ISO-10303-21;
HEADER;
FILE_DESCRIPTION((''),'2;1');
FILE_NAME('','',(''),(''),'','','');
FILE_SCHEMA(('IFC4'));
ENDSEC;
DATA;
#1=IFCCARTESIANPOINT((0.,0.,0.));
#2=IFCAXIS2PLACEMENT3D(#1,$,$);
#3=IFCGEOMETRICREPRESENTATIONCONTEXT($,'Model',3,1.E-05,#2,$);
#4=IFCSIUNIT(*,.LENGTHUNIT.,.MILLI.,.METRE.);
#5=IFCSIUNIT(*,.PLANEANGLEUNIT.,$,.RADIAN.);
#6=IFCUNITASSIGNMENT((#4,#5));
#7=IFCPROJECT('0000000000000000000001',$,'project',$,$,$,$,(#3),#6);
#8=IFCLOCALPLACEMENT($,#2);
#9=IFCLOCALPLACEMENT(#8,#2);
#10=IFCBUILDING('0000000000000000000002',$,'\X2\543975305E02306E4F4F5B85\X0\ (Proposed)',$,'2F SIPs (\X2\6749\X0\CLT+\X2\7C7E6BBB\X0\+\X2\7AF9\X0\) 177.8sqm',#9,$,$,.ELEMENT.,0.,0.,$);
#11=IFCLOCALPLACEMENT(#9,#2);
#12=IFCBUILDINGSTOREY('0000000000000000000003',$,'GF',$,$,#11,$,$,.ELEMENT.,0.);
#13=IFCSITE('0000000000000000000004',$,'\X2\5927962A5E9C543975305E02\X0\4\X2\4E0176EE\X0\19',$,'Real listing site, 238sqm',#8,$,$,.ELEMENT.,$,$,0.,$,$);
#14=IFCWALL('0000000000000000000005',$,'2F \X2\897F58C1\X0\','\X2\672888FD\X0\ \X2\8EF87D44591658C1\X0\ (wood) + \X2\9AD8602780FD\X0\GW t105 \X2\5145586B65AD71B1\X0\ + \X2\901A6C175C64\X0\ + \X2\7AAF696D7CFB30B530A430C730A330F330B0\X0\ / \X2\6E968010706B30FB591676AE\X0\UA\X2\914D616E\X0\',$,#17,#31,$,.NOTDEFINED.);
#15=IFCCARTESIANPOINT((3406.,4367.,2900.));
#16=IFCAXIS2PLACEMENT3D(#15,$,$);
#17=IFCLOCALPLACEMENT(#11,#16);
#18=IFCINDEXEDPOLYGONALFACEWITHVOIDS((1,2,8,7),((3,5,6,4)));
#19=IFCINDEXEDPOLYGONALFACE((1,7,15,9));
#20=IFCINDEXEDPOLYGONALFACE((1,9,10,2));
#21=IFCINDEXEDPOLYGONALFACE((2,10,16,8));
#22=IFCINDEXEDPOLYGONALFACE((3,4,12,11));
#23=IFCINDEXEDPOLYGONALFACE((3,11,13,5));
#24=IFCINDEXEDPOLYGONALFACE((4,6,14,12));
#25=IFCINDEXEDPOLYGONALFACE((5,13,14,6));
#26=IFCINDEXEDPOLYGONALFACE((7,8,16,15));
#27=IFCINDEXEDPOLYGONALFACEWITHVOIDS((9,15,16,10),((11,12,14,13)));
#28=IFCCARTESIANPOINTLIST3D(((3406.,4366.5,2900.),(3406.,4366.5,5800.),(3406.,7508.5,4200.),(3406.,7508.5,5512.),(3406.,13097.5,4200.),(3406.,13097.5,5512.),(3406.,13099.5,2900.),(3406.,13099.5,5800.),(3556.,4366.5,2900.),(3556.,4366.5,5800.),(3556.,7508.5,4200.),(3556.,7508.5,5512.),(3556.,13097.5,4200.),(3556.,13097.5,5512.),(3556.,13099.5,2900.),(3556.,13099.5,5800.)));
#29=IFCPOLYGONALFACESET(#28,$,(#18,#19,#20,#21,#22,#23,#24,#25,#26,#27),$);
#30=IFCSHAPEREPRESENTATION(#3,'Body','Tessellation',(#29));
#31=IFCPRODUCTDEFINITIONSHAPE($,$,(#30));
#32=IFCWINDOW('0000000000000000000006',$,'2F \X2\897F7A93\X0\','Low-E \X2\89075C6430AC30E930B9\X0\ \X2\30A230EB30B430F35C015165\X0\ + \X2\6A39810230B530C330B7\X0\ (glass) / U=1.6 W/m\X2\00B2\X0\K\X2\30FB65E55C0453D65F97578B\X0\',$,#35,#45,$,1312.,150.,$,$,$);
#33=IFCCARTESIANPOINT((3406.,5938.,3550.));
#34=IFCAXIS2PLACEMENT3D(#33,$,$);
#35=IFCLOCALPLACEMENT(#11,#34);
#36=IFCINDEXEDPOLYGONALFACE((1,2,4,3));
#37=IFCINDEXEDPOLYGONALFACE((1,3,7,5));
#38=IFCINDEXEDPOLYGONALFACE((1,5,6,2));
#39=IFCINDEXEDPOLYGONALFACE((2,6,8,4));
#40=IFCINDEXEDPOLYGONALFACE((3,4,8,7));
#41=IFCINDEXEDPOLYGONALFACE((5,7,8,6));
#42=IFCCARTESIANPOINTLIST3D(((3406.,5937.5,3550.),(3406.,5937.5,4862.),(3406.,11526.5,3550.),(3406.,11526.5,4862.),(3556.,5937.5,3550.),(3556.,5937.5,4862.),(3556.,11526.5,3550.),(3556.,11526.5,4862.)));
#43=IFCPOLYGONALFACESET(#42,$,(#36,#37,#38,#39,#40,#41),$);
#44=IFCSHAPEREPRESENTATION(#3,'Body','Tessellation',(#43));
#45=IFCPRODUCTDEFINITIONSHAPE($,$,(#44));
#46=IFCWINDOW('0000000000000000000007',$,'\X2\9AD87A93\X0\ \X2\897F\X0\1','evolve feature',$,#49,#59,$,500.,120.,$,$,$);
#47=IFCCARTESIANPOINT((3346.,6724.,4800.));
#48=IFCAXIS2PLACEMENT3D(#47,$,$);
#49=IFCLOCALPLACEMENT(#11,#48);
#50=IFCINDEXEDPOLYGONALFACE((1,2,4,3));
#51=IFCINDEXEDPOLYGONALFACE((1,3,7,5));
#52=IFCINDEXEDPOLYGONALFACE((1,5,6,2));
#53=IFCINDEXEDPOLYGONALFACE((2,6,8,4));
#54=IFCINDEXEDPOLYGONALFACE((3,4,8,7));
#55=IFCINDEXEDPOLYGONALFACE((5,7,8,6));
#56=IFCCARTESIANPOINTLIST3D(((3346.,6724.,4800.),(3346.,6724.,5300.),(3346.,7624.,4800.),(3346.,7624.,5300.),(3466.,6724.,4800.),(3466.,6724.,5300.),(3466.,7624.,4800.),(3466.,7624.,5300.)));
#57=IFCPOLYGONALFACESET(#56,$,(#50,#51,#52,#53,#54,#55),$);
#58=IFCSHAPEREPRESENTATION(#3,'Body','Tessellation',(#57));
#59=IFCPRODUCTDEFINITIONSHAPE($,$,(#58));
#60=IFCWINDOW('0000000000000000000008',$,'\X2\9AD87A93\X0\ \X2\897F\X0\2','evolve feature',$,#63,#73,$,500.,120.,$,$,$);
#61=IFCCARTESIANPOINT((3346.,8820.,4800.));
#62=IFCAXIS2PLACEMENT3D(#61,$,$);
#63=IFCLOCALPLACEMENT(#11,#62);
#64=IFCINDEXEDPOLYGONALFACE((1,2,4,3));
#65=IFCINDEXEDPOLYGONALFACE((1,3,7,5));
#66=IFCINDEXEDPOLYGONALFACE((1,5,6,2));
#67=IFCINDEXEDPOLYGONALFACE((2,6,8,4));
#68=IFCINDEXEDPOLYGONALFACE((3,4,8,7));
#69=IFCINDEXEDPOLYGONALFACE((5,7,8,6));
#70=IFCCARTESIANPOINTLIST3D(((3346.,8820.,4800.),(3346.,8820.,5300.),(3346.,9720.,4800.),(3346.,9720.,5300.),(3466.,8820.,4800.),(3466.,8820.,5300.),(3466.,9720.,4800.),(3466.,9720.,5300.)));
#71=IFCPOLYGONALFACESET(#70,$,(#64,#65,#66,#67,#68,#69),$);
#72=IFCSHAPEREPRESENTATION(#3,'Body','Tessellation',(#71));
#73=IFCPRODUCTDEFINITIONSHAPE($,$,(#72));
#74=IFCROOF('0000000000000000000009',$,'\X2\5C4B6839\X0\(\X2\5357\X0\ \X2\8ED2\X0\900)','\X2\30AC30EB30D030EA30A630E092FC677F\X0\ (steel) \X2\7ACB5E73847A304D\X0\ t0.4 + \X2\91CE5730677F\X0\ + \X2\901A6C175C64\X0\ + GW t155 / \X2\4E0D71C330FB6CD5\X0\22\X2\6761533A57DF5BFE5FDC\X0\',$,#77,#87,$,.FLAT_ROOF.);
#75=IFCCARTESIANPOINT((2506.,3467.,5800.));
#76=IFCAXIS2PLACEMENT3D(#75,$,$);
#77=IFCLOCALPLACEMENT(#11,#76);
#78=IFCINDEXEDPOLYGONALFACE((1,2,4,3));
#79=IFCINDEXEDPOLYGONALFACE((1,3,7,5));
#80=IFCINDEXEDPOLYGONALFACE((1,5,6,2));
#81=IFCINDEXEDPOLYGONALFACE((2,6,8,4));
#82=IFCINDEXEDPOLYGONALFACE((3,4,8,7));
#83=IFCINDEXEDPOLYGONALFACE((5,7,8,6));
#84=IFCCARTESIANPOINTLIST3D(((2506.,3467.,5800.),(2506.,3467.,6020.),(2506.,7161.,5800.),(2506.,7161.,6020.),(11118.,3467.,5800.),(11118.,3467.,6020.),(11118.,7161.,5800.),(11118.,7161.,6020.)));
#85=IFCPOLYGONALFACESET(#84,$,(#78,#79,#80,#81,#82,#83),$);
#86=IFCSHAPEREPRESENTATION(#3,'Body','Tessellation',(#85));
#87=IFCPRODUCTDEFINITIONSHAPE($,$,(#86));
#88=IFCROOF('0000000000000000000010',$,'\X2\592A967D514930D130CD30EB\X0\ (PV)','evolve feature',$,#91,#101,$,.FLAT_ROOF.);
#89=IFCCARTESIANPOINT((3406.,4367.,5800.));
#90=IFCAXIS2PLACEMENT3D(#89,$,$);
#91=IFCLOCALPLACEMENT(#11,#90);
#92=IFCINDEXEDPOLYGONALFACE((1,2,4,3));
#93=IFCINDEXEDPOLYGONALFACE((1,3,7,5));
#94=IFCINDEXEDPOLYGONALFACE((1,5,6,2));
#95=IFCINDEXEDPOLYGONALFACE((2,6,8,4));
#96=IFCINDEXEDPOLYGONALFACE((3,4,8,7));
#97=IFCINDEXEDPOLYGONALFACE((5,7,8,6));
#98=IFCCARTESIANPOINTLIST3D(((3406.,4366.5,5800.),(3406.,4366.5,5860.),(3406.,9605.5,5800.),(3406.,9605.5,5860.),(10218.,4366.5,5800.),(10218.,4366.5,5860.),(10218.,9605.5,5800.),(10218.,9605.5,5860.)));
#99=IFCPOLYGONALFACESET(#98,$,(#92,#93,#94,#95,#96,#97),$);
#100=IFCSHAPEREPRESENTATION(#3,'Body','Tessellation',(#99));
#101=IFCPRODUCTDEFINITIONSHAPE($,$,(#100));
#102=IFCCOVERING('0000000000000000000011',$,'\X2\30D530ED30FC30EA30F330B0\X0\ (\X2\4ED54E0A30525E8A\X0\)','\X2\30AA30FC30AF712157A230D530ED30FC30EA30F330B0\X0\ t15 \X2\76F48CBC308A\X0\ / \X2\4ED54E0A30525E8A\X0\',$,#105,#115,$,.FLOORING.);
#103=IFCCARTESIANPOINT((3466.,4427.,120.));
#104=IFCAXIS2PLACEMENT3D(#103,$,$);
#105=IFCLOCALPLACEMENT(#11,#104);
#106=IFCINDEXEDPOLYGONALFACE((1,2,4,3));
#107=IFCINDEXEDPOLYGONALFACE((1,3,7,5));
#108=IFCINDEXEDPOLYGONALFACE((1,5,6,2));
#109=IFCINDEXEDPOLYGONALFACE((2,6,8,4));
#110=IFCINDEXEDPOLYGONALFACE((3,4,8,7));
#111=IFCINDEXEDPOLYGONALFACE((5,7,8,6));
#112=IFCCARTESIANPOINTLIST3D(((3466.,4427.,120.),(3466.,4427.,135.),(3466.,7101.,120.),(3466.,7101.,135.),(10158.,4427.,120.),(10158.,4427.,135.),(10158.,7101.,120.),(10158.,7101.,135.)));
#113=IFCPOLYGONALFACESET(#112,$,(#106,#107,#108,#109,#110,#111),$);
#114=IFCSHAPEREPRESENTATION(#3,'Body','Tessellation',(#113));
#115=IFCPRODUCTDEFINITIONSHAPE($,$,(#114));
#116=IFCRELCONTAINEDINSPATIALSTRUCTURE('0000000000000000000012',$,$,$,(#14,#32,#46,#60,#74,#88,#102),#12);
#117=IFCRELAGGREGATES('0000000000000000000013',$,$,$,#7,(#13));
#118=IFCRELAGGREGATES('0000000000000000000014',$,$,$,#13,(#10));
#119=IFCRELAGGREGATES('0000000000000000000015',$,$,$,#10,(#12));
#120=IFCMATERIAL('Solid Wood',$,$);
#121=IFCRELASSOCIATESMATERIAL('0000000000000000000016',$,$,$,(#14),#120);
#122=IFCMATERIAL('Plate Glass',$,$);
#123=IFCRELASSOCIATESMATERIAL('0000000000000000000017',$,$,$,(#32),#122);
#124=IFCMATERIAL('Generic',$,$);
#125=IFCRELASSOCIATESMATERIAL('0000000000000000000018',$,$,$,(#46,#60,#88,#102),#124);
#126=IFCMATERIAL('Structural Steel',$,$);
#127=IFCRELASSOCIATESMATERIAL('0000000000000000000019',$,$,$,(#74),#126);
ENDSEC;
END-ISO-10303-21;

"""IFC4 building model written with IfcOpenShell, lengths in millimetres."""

from ifc_helpers import new_model, si_unit, frame, frame_2d, origin, place, context, project, spatial, rectangle, extrude, material, element, fill, save


model = new_model("IFC4")

# Units and contexts
model_context = context("Model", 3, precision=1e-05, world=origin())
ifc_project = project(units=[si_unit("LENGTHUNIT", "METRE", prefix="MILLI"), si_unit("PLANEANGLEUNIT", "RADIAN")], contexts=[model_context])

# Site, building, storey
site_placement = place(None, origin())
site = spatial("IfcSite", under=ifc_project, at=site_placement, Name="大阪府吹田市4丁目19", ObjectType="Real listing site, 238sqm", CompositionType="ELEMENT", RefElevation=0.0)
building_placement = place(site_placement, origin())
building = spatial("IfcBuilding", under=site, at=building_placement, Name="吹田市の住宅 (Proposed)", ObjectType="2F SIPs (杉CLT+籾殻+竹) 177.8sqm", CompositionType="ELEMENT", ElevationOfRefHeight=0.0, ElevationOfTerrain=0.0)
storey_placement = place(building_placement, origin())
storey = spatial("IfcBuildingStorey", under=building, at=storey_placement, Name="GF", CompositionType="ELEMENT", Elevation=0.0)

# Shared definitions
ifc_material_1 = material(Name="Solid Wood")
ifc_material_2 = material(Name="Generic")

# Shared definitions
ifc_material_3 = material(Name="Plate Glass")

# Wall, openings, windows
wall_1_placement = place(storey_placement, frame((3406.0, 4367.0, 2900.0)))
wall_1 = element("IfcWall", 1, at=wall_1_placement, inside=storey, material=ifc_material_1, Name="2F 西壁", Description="木製 軸組外壁 (wood) + 高性能GW t105 充填断熱 + 通気層 + 窯業系サイディング / 準耐火・外皮UA配慮", PredefinedType="NOTDEFINED", context=model_context, shape_type="SweptSolid", body=[
    extrude(rectangle(XDim=150.0, YDim=8733.0, at=frame_2d((75.0, 4366.0))), frame((3406.0, 4367.0, 2900.0)), (0.0, 0.0, 1.0), 2900.0),
])
opening_1_placement = place(storey_placement, frame((3406.0, 5938.0, 3550.0)))
opening_1 = element("IfcOpeningElement", 2, at=opening_1_placement, cuts=wall_1, PredefinedType="NOTDEFINED", context=model_context, shape_type="SweptSolid", body=[
    extrude(rectangle(XDim=150.0, YDim=5589.0, at=frame_2d((75.0, 2794.0))), frame((3406.0, 5938.0, 3550.0)), (0.0, 0.0, 1.0), 1312.0),
])
opening_2_placement = place(storey_placement, frame((3346.0, 6724.0, 4800.0)))
opening_2 = element("IfcOpeningElement", 3, at=opening_2_placement, cuts=wall_1, PredefinedType="NOTDEFINED", context=model_context, shape_type="SweptSolid", body=[
    extrude(rectangle(XDim=120.0, YDim=900.0, at=frame_2d((60.0, 450.0))), frame((3346.0, 6724.0, 4800.0)), (0.0, 0.0, 1.0), 500.0),
])
opening_3_placement = place(storey_placement, frame((3346.0, 8820.0, 4800.0)))
opening_3 = element("IfcOpeningElement", 4, at=opening_3_placement, cuts=wall_1, PredefinedType="NOTDEFINED", context=model_context, shape_type="SweptSolid", body=[
    extrude(rectangle(XDim=120.0, YDim=900.0, at=frame_2d((60.0, 450.0))), frame((3346.0, 8820.0, 4800.0)), (0.0, 0.0, 1.0), 500.0),
])
window_1_placement = place(storey_placement, frame((3406.0, 5938.0, 3550.0)))
window_1 = element("IfcWindow", 5, at=window_1_placement, inside=storey, material=ifc_material_3, Name="2F 西窓", Description="Low-E 複層ガラス アルゴン封入 + 樹脂サッシ (glass) / U=1.6 W/m²K・日射取得型", OverallHeight=1312.0, OverallWidth=150.0, context=model_context, shape_type="SweptSolid", body=[
    extrude(rectangle(XDim=150.0, YDim=5589.0, at=frame_2d((75.0, 2794.0))), frame((3406.0, 5938.0, 3550.0)), (0.0, 0.0, 1.0), 1312.0),
])
fill(opening_1, window_1)
window_2_placement = place(storey_placement, frame((3346.0, 6724.0, 4800.0)))
window_2 = element("IfcWindow", 6, at=window_2_placement, inside=storey, material=ifc_material_2, Name="高窓 西1", Description="evolve feature", OverallHeight=500.0, OverallWidth=120.0, context=model_context, shape_type="SweptSolid", body=[
    extrude(rectangle(XDim=120.0, YDim=900.0, at=frame_2d((60.0, 450.0))), frame((3346.0, 6724.0, 4800.0)), (0.0, 0.0, 1.0), 500.0),
])
fill(opening_2, window_2)
window_3_placement = place(storey_placement, frame((3346.0, 8820.0, 4800.0)))
window_3 = element("IfcWindow", 7, at=window_3_placement, inside=storey, material=ifc_material_2, Name="高窓 西2", Description="evolve feature", OverallHeight=500.0, OverallWidth=120.0, context=model_context, shape_type="SweptSolid", body=[
    extrude(rectangle(XDim=120.0, YDim=900.0, at=frame_2d((60.0, 450.0))), frame((3346.0, 8820.0, 4800.0)), (0.0, 0.0, 1.0), 500.0),
])
fill(opening_3, window_3)

# Roofs
ifc_material_4 = material(Name="Structural Steel")
roof_1_placement = place(storey_placement, frame((2506.0, 3467.0, 5800.0)))
element("IfcRoof", 8, at=roof_1_placement, inside=storey, material=ifc_material_4, Name="屋根(南 軒900)", Description="ガルバリウム鋼板 (steel) 立平葺き t0.4 + 野地板 + 通気層 + GW t155 / 不燃・法22条区域対応", PredefinedType="FLAT_ROOF", context=model_context, shape_type="SweptSolid", body=[
    extrude(rectangle(XDim=8612.0, YDim=3694.0, at=frame_2d((4306.0, 1847.0))), frame((2506.0, 3467.0, 5800.0)), (0.0, 0.0, 1.0), 220.0),
])
roof_2_placement = place(storey_placement, frame((3406.0, 4367.0, 5800.0)))
element("IfcRoof", 9, at=roof_2_placement, inside=storey, material=ifc_material_2, Name="太陽光パネル (PV)", Description="evolve feature", PredefinedType="FLAT_ROOF", context=model_context, shape_type="SweptSolid", body=[
    extrude(rectangle(XDim=6812.0, YDim=5239.0, at=frame_2d((3406.0, 2619.0))), frame((3406.0, 4367.0, 5800.0)), (0.0, 0.0, 1.0), 60.0),
])

# Covering
covering_placement = place(storey_placement, frame((3466.0, 4427.0, 120.0)))
element("IfcCovering", 10, at=covering_placement, inside=storey, material=ifc_material_2, Name="フローリング (仕上げ床)", Description="オーク無垢フローリング t15 直貼り / 仕上げ床", PredefinedType="FLOORING", context=model_context, shape_type="SweptSolid", body=[
    extrude(rectangle(XDim=6692.0, YDim=2674.0, at=frame_2d((3346.0, 1337.0))), frame((3466.0, 4427.0, 120.0)), (0.0, 0.0, 1.0), 15.0),
])

save(model, "model.ifc")
